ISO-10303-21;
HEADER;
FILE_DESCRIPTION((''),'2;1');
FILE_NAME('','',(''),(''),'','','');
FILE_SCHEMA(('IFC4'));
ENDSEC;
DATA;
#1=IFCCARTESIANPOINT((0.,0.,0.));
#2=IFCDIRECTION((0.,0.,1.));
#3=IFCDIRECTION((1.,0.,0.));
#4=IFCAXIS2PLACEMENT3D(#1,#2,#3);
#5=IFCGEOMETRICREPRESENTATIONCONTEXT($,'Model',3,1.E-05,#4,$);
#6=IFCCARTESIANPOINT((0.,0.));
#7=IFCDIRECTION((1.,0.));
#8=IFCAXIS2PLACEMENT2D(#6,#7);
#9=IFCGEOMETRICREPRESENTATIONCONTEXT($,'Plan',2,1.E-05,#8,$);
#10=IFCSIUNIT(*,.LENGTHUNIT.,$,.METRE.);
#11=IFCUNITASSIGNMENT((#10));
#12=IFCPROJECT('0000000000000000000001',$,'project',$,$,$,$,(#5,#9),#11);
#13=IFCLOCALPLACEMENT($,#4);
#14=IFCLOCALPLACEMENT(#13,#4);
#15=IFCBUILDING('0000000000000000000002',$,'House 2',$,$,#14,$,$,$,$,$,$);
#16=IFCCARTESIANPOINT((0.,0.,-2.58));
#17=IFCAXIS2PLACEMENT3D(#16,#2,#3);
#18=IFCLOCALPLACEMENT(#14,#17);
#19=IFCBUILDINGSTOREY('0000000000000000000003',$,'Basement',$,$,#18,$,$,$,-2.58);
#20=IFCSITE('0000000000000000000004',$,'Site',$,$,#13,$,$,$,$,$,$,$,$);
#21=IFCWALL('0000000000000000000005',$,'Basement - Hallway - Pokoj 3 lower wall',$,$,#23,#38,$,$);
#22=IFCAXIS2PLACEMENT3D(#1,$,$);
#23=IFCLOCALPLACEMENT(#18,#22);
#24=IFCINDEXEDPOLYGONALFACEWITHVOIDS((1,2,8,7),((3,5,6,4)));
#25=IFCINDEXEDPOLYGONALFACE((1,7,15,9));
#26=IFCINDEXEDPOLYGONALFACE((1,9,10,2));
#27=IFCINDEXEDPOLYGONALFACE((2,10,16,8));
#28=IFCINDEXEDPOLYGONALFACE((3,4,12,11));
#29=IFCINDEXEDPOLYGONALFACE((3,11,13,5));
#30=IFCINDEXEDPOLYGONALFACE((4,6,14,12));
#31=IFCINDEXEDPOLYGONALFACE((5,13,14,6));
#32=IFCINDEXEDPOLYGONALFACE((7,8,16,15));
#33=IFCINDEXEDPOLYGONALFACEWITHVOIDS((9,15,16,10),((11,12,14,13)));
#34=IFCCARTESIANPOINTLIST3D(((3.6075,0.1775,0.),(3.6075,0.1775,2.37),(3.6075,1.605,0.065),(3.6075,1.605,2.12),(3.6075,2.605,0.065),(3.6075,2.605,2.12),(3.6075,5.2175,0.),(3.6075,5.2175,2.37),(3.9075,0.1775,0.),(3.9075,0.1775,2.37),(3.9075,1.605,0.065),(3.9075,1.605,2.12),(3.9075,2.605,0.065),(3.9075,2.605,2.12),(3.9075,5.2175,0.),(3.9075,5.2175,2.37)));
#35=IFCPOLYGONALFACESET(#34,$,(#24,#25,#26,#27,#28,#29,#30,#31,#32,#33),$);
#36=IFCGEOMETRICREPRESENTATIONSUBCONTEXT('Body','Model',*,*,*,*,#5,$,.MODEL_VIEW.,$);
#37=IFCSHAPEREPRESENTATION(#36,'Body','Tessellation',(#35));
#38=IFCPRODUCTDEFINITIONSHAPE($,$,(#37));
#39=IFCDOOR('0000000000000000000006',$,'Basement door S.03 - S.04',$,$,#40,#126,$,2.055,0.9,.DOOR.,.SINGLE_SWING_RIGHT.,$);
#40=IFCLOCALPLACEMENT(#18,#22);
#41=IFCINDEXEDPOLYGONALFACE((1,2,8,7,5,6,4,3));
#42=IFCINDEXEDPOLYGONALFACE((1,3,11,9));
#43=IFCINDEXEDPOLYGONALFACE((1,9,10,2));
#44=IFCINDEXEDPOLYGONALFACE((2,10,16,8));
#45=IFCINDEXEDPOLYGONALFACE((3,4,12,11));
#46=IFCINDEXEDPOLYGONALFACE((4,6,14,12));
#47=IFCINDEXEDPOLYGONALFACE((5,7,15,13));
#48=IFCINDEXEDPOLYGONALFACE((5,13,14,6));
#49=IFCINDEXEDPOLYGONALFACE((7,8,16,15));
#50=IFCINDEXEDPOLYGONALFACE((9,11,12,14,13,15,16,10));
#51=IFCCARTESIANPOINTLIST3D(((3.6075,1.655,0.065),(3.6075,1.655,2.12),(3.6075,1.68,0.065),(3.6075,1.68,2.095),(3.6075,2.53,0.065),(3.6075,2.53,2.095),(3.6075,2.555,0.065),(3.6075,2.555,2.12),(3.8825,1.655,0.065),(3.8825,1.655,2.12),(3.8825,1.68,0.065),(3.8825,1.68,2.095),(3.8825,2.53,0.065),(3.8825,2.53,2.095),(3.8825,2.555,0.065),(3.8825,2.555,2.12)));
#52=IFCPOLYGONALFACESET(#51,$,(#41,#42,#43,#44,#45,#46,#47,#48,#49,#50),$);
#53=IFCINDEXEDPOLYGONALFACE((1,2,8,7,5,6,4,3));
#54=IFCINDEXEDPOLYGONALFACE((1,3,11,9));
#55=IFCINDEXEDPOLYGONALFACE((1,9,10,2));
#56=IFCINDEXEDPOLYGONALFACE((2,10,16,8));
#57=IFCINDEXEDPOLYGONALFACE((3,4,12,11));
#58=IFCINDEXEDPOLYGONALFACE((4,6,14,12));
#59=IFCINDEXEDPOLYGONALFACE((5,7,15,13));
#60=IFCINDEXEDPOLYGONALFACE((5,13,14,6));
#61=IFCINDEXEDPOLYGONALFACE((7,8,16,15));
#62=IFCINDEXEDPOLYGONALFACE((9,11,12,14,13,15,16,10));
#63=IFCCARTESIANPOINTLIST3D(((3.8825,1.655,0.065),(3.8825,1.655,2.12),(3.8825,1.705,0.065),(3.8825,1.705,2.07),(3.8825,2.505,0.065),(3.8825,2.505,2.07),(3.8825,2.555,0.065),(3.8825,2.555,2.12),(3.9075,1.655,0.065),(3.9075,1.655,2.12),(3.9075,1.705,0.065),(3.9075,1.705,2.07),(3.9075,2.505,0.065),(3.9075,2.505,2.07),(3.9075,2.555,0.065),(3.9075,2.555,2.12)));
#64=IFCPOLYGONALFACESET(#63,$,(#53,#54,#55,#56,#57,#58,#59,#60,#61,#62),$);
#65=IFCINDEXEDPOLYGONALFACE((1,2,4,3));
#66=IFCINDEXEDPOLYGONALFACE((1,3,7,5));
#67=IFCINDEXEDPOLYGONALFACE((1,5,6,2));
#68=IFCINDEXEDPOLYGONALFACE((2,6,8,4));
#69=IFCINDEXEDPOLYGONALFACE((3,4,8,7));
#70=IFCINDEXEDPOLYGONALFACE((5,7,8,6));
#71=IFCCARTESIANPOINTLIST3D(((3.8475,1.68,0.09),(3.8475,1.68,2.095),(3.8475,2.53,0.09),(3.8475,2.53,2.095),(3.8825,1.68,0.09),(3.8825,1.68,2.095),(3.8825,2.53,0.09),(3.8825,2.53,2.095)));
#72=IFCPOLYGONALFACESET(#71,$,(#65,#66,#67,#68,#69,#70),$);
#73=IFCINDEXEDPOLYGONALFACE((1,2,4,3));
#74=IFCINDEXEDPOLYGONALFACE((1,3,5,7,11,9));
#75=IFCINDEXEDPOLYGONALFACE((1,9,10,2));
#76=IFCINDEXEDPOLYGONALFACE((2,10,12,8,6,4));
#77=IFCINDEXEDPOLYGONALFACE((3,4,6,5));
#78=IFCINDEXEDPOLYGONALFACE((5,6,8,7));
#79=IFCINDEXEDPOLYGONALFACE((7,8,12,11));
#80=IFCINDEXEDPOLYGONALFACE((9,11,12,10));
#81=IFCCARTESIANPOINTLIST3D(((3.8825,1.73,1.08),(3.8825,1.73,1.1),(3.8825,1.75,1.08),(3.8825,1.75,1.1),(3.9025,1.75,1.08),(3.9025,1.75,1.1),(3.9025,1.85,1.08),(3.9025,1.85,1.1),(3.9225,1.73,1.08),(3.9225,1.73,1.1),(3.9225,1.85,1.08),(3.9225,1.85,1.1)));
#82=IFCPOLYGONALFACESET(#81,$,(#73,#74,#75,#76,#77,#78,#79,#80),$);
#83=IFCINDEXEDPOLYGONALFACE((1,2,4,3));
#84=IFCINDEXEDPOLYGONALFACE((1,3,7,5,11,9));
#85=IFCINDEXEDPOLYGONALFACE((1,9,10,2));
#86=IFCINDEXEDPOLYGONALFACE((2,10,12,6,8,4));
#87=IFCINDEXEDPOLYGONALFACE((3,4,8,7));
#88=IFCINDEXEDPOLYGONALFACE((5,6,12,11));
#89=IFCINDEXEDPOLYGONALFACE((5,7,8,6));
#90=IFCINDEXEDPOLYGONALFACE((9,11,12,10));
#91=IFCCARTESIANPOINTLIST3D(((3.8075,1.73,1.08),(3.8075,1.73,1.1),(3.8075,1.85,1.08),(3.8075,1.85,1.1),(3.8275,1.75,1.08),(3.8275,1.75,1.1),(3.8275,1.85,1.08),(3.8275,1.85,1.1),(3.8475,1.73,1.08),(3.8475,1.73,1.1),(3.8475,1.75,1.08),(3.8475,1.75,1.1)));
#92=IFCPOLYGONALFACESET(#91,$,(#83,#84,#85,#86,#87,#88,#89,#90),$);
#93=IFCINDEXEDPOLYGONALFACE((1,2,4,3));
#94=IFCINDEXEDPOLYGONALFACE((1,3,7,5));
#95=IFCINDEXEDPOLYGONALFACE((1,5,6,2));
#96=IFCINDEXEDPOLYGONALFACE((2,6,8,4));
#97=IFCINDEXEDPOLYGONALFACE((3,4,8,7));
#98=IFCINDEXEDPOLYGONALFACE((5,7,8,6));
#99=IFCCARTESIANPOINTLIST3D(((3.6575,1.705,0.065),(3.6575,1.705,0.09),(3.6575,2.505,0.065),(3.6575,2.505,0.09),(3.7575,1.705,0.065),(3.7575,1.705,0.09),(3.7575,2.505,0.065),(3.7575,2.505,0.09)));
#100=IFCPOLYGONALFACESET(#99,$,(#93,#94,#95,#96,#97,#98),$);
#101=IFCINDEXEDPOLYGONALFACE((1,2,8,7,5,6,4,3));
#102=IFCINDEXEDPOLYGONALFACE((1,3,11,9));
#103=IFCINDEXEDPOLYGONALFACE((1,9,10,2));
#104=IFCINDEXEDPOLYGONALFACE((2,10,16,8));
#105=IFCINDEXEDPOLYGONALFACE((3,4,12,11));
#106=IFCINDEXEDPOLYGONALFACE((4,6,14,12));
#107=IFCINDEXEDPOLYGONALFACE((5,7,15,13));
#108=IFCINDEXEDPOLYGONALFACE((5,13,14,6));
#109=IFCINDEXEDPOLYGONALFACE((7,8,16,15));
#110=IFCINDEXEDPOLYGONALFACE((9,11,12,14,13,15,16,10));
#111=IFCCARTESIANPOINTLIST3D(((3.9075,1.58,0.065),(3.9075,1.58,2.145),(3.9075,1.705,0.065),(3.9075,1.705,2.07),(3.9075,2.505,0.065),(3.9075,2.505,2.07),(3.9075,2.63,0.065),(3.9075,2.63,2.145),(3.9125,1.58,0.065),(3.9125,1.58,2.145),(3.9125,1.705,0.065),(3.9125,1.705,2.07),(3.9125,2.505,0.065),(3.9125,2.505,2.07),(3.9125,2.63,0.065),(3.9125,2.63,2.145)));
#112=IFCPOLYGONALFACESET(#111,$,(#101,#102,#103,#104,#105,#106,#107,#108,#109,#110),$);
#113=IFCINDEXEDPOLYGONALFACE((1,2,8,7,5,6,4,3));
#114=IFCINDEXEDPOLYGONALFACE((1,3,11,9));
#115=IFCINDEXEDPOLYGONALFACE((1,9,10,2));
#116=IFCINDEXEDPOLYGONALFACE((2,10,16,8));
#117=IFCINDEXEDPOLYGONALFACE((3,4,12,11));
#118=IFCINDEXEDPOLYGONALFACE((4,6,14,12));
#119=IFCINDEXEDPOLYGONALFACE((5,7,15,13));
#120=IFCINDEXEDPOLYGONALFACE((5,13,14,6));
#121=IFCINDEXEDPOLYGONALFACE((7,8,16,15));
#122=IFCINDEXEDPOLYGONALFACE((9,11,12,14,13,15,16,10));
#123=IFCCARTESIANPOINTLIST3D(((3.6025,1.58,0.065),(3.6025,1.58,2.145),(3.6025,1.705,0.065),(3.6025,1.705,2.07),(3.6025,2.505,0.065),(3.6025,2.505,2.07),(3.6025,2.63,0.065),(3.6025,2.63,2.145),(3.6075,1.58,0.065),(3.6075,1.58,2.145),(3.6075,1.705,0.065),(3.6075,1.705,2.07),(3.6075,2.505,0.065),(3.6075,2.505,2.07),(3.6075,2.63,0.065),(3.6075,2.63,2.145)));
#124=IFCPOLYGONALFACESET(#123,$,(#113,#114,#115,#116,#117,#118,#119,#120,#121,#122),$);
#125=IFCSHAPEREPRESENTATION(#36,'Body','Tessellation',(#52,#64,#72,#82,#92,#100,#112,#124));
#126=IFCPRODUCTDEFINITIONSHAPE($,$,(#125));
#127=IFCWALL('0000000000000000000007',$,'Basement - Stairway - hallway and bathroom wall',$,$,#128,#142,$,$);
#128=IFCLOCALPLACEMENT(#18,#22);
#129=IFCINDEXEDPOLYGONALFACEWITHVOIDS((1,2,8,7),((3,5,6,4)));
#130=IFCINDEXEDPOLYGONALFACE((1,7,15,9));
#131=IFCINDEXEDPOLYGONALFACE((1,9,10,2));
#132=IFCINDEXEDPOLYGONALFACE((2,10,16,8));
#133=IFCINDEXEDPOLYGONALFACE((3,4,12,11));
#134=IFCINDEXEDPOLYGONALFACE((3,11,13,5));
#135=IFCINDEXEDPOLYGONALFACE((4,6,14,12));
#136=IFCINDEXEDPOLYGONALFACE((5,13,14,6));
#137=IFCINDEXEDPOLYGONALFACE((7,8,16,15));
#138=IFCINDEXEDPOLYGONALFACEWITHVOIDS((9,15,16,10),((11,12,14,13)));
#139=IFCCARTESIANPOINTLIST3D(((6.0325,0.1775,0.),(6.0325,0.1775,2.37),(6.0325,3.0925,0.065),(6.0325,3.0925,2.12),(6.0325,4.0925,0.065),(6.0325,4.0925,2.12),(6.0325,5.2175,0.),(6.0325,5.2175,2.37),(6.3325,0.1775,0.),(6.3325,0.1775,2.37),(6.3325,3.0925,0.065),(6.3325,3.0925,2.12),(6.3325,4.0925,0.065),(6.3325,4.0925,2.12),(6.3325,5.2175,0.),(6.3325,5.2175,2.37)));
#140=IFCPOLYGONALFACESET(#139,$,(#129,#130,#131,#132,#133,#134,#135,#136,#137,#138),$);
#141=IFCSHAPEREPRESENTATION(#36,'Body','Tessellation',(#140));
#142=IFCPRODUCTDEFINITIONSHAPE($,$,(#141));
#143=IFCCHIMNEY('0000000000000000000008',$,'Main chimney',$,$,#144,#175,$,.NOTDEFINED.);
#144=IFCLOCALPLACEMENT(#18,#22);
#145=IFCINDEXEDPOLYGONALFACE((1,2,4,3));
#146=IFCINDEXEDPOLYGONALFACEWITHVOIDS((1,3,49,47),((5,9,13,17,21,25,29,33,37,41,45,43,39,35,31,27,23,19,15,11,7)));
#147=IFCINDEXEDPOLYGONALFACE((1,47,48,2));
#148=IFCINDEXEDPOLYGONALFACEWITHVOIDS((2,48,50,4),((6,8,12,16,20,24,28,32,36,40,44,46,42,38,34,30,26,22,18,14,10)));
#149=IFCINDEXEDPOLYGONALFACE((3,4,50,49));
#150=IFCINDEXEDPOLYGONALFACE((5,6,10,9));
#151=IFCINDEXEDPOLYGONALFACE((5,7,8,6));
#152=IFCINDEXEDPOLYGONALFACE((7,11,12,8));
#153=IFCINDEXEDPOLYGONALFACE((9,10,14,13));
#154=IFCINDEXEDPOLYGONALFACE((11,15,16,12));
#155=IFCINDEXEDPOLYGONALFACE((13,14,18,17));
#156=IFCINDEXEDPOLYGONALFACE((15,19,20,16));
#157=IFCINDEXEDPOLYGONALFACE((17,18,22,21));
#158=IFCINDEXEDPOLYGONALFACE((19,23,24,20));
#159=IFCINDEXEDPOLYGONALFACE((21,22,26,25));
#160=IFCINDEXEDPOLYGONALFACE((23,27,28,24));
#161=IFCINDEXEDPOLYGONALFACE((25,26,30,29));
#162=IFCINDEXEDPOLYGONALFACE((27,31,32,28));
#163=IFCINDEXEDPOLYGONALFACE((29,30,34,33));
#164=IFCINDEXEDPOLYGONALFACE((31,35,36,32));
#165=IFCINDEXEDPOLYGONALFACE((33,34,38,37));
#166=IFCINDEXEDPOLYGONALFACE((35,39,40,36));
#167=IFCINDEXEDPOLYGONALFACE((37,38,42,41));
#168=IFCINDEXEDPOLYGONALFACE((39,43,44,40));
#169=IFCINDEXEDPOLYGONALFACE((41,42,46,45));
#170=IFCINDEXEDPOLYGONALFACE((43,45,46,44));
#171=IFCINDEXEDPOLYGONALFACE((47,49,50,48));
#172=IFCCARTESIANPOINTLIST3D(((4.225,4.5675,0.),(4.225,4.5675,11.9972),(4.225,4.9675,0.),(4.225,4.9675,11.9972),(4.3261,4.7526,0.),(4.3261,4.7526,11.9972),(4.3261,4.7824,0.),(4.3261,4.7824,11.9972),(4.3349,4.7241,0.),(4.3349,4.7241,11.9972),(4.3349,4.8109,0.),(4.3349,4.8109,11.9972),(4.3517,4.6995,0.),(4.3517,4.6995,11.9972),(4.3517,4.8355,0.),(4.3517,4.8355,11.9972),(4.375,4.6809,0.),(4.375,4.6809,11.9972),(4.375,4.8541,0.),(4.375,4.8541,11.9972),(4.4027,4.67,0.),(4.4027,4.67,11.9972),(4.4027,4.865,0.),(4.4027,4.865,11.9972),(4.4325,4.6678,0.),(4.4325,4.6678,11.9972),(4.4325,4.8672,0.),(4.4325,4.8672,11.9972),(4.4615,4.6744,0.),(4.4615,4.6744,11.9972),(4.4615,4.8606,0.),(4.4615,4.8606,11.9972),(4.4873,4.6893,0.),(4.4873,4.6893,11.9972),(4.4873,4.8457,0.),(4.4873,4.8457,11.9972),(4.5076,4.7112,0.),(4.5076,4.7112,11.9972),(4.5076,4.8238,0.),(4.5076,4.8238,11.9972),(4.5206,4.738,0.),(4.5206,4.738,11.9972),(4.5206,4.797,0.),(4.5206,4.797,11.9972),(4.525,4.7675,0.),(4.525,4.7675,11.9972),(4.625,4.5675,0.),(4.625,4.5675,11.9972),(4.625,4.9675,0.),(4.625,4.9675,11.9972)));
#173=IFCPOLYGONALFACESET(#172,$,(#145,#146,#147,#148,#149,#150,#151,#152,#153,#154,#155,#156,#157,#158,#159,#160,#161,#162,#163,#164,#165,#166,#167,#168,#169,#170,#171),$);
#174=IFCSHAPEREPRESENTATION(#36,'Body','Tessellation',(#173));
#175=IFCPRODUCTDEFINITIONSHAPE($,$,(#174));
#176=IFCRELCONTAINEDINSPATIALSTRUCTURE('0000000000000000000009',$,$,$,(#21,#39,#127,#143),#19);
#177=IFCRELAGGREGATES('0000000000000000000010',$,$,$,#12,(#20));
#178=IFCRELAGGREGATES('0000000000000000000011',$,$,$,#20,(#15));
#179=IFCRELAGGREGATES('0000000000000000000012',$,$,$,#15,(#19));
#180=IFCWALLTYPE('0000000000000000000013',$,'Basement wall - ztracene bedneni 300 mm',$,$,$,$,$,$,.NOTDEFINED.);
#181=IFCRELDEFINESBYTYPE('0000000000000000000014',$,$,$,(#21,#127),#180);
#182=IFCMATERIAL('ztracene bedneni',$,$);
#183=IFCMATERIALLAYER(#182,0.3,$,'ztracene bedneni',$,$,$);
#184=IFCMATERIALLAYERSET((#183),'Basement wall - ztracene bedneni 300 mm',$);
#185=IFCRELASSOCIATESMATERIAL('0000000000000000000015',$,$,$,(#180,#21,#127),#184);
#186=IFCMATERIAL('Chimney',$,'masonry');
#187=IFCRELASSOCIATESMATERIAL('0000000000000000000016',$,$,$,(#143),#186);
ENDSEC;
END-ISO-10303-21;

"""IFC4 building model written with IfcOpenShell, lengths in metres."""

from ifc_helpers import new_model, entity, si_unit, frame, origin_with_axes, origin_2d_with_axis, place, context, subcontext, project, spatial, line, indexed_curve, circle_curve, outline, extrude, shape, source, transform, mapped, material, layer, layer_set, layer_usage, type_object, element, fill, save


model = new_model("IFC4")

# Units and contexts
model_context = context("Model", 3, precision=1e-05, world=origin_with_axes())
plan_context = context("Plan", 2, precision=1e-05, world=origin_2d_with_axis())
body_context_1 = subcontext(model_context, "Body", "Model", "MODEL_VIEW")
body_context_2 = subcontext(plan_context, "Body", "Plan", "PLAN_VIEW")
ifc_project = project(units=[si_unit("LENGTHUNIT", "METRE")], contexts=[model_context, plan_context])

# Site, building, storey
site_placement = place(None, origin_with_axes())
site = spatial("IfcSite", under=ifc_project, at=site_placement, Name="Site")
building_placement = place(site_placement, origin_with_axes())
building = spatial("IfcBuilding", under=site, at=building_placement, Name="House 2")
storey_placement = place(building_placement, frame((0.0, 0.0, -2.58), z_axis=(0.0, 0.0, 1.0), x_axis=(1.0, 0.0, 0.0)))
storey = spatial("IfcBuildingStorey", under=building, at=storey_placement, Name="Basement", Elevation=-2.58)

# Shared definitions
ifc_material_1 = material(Name="ztracene bedneni")
ifc_layer = layer(ifc_material_1, 0.3, Name="ztracene bedneni")
ifc_layer_set = layer_set([ifc_layer], Name="Basement wall - ztracene bedneni 300 mm")
wall_type = type_object("IfcWallType", Name="Basement wall - ztracene bedneni 300 mm", PredefinedType="NOTDEFINED", material=ifc_layer_set)

# Wall, opening, door
ifc_layer_usage_1 = layer_usage(ifc_layer_set, "AXIS2", "NEGATIVE", 0.15)
wall_1_placement = place(storey_placement, frame((3.7575, 0.1775, 0.0), z_axis=(0.0, 0.0, 1.0), x_axis=(0.0, 1.0, 0.0)))
wall_1 = element("IfcWall", 1, at=wall_1_placement, inside=storey, type_object=wall_type, material=ifc_layer_usage_1, Name="Basement - Hallway - Pokoj 3 lower wall", context=body_context_1, shape_type="SweptSolid", body=[
    extrude(outline(indexed_curve([(0.0, 0.0), (0.0, 0.3), (5.04, 0.3), (5.04, 0.0), (0.0, 0.0)], self_intersect=False)), frame((0.0, -0.15, 0.0), z_axis=(0.0, 0.0, 1.0), x_axis=(1.0, 0.0, 0.0)), (0.0, 0.0, 1.0), 2.37),
])
opening_1_placement = place(wall_1_placement, frame((1.4275, 0.0, 0.065), z_axis=(0.0, 0.0, 1.0), x_axis=(1.0, 0.0, 0.0)))
opening_1 = element("IfcOpeningElement", 2, at=opening_1_placement, cuts=wall_1, PredefinedType="OPENING", context=body_context_1, shape_type="SweptSolid", body=[
    extrude(outline(indexed_curve([(0.0, 0.0), (0.0, 0.4), (1.0, 0.4), (1.0, 0.0), (0.0, 0.0)], self_intersect=False)), frame((0.0, -0.2, 0.0), z_axis=(0.0, 0.0, 1.0), x_axis=(1.0, 0.0, 0.0)), (0.0, 0.0, 1.0), 2.055),
])
shared_indexed_poly_curve_1 = entity("IfcIndexedPolyCurve", entity("IfcCartesianPointList2D", [[-0.075, 0.0], [-0.075, 2.08], [0.975, 2.08], [0.975, 0.0], [0.85, 0.0], [0.85, 2.005], [0.05, 2.005], [0.05, 0.0]]), [entity("IfcLineIndex", [1, 2, 3, 4, 5, 6, 7, 8, 1])])
shared_shape_1 = source(origin_with_axes(), body_context_2, "Body", "Curve2D", [
    entity("IfcIndexedPolyCurve", entity("IfcCartesianPointList2D", [[0.0, -0.15], [0.0, 0.15], [0.025, 0.15], [0.025, -0.125], [0.05, -0.125], [0.05, -0.15]]), [entity("IfcLineIndex", [1, 2, 3, 4, 5, 6, 1])]),
    entity("IfcIndexedPolyCurve", entity("IfcCartesianPointList2D", [[0.9, -0.15], [0.9, 0.15], [0.875, 0.15], [0.875, -0.125], [0.85, -0.125], [0.85, -0.15]]), [entity("IfcLineIndex", [1, 2, 3, 4, 5, 6, 1])]),
    entity("IfcTrimmedCurve", entity("IfcEllipse", entity("IfcAxis2Placement2D", entity("IfcCartesianPoint", [0.84, -0.15]), entity("IfcDirection", [1.0, 0.0])), 0.815, 0.85), [entity("IfcCartesianPoint", [0.025, -0.15])], [entity("IfcCartesianPoint", [0.84, -1.0])], True, "CARTESIAN"),
    entity("IfcIndexedPolyCurve", entity("IfcCartesianPointList2D", [[0.875, -0.15], [0.84, -0.15], [0.84, -1.0], [0.875, -1.0]]), [entity("IfcLineIndex", [1, 2, 3, 4, 1])]),
])
door_1_placement = place(opening_1_placement, frame((0.05, 0.0, 0.0), z_axis=(0.0, 0.0, 1.0), x_axis=(1.0, 0.0, 0.0)))
door_1 = element("IfcDoor", 3, at=door_1_placement, inside=storey, Name="Basement door S.03 - S.04", OperationType="SINGLE_SWING_RIGHT", OverallHeight=2.055, OverallWidth=0.9, PredefinedType="DOOR", shapes=[
    shape(body_context_1, "Body", "SweptSolid", [extrude(outline(indexed_curve([(0.0, 0.0), (0.0, 2.055), (0.9, 2.055), (0.9, 0.0), (0.875, 0.0), (0.875, 2.03), (0.025, 2.03), (0.025, 0.0)], segments=[line(1, 2, 3, 4, 5, 6, 7, 8, 1)])), frame((0.0, -0.125, 0.0), z_axis=(0.0, -1.0, 0.0), x_axis=(1.0, 0.0, 0.0)), (0.0, 0.0, -1.0), 0.275), extrude(outline(indexed_curve([(0.0, 0.0), (0.0, 2.055), (0.9, 2.055), (0.9, 0.0), (0.85, 0.0), (0.85, 2.005), (0.05, 2.005), (0.05, 0.0)], segments=[line(1, 2, 3, 4, 5, 6, 7, 8, 1)])), frame((0.0, -0.15, 0.0), z_axis=(0.0, -1.0, 0.0), x_axis=(1.0, 0.0, 0.0)), (0.0, 0.0, -1.0), 0.025), extrude(outline(indexed_curve([(0.0, 0.0), (0.85, 0.0), (0.85, 0.035), (0.0, 0.035)], segments=[line(1, 2, 3, 4, 1)])), frame((0.025, -0.125, 0.025), z_axis=(0.0, 0.0, 1.0), x_axis=(1.0, 0.0, 0.0)), (0.0, 0.0, 1.0), 2.005), extrude(outline(indexed_curve([(0.0, 0.0), (0.0, -0.04), (0.12, -0.04), (0.12, -0.02), (0.02, -0.02), (0.02, 0.0)], segments=[line(1, 2, 3, 4, 5, 6, 1)])), frame((0.075, -0.125, 1.015), z_axis=(0.0, 0.0, 1.0), x_axis=(1.0, 0.0, 0.0)), (0.0, 0.0, 1.0), 0.02), extrude(outline(indexed_curve([(0.0, 0.0), (0.0, 0.04), (0.12, 0.04), (0.12, 0.02), (0.02, 0.02), (0.02, 0.0)], segments=[line(1, 2, 3, 4, 5, 6, 1)])), frame((0.075, -0.09, 1.015), z_axis=(0.0, 0.0, 1.0), x_axis=(1.0, 0.0, 0.0)), (0.0, 0.0, 1.0), 0.02), extrude(outline(indexed_curve([(0.0, 0.0), (0.8, 0.0), (0.8, 0.1), (0.0, 0.1)], segments=[line(1, 2, 3, 4, 1)])), frame((0.05, 0.0, 0.0), z_axis=(0.0, 0.0, 1.0), x_axis=(1.0, 0.0, 0.0)), (0.0, 0.0, 1.0), 0.025), entity("IfcExtrudedAreaSolid", entity("IfcArbitraryClosedProfileDef", "AREA", None, shared_indexed_poly_curve_1), entity("IfcAxis2Placement3D", entity("IfcCartesianPoint", [0.0, -0.155, 0.0]), entity("IfcDirection", [0.0, -1.0, 0.0]), entity("IfcDirection", [1.0, 0.0, 0.0])), entity("IfcDirection", [0.0, 0.0, -1.0]), 0.005), entity("IfcExtrudedAreaSolid", entity("IfcArbitraryClosedProfileDef", "AREA", None, shared_indexed_poly_curve_1), entity("IfcAxis2Placement3D", entity("IfcCartesianPoint", [0.0, 0.15, 0.0]), entity("IfcDirection", [0.0, -1.0, 0.0]), entity("IfcDirection", [1.0, 0.0, 0.0])), entity("IfcDirection", [0.0, 0.0, -1.0]), 0.005)]),
    shape(body_context_2, "Body", "MappedRepresentation", [mapped(shared_shape_1, transform((0.0, 0.0, 1.0), x_axis=(1.0, 0.0, 0.0), y_axis=(0.0, 1.0, 0.0), z_axis=(0.0, 0.0, 1.0), scale=1.0))]),
])
fill(opening_1, door_1)

# Wall, opening
ifc_layer_usage_2 = layer_usage(ifc_layer_set, "AXIS2", "NEGATIVE", 0.15)
wall_2_placement = place(storey_placement, frame((6.1825, 0.1775, 0.0), z_axis=(0.0, 0.0, 1.0), x_axis=(0.0, 1.0, 0.0)))
wall_2 = element("IfcWall", 4, at=wall_2_placement, inside=storey, type_object=wall_type, material=ifc_layer_usage_2, Name="Basement - Stairway - hallway and bathroom wall", context=body_context_1, shape_type="SweptSolid", body=[
    extrude(outline(indexed_curve([(0.0, 0.0), (0.0, 0.3), (5.04, 0.3), (5.04, 0.0), (0.0, 0.0)], self_intersect=False)), frame((0.0, -0.15, 0.0), z_axis=(0.0, 0.0, 1.0), x_axis=(1.0, 0.0, 0.0)), (0.0, 0.0, 1.0), 2.37),
])
opening_2_placement = place(wall_2_placement, frame((2.915, 0.0, 0.065), z_axis=(0.0, 0.0, 1.0), x_axis=(1.0, 0.0, 0.0)))
element("IfcOpeningElement", 5, at=opening_2_placement, cuts=wall_2, PredefinedType="OPENING", context=body_context_1, shape_type="SweptSolid", body=[
    extrude(outline(indexed_curve([(0.0, 0.0), (0.0, 0.4), (1.0, 0.4), (1.0, 0.0), (0.0, 0.0)], self_intersect=False)), frame((0.0, -0.2, 0.0), z_axis=(0.0, 0.0, 1.0), x_axis=(1.0, 0.0, 0.0)), (0.0, 0.0, 1.0), 2.055),
])

# Chimney
ifc_material_2 = material(Name="Chimney", Category="masonry")
chimney_placement = place(storey_placement, frame((4.425, 4.7675, 0.0), z_axis=(0.0, 0.0, 1.0), x_axis=(1.0, 0.0, 0.0)))
element("IfcChimney", 6, at=chimney_placement, inside=storey, material=ifc_material_2, Name="Main chimney", PredefinedType="NOTDEFINED", context=body_context_1, shape_type="SweptSolid", body=[
    extrude(outline(indexed_curve([(-0.2, -0.2), (0.2, -0.2), (0.2, 0.2), (-0.2, 0.2), (-0.2, -0.2)], self_intersect=False), holes=[circle_curve(origin_2d_with_axis(), 0.1)]), origin_with_axes(), (0.0, 0.0, 1.0), 11.9972),
])

save(model, "model.ifc")
